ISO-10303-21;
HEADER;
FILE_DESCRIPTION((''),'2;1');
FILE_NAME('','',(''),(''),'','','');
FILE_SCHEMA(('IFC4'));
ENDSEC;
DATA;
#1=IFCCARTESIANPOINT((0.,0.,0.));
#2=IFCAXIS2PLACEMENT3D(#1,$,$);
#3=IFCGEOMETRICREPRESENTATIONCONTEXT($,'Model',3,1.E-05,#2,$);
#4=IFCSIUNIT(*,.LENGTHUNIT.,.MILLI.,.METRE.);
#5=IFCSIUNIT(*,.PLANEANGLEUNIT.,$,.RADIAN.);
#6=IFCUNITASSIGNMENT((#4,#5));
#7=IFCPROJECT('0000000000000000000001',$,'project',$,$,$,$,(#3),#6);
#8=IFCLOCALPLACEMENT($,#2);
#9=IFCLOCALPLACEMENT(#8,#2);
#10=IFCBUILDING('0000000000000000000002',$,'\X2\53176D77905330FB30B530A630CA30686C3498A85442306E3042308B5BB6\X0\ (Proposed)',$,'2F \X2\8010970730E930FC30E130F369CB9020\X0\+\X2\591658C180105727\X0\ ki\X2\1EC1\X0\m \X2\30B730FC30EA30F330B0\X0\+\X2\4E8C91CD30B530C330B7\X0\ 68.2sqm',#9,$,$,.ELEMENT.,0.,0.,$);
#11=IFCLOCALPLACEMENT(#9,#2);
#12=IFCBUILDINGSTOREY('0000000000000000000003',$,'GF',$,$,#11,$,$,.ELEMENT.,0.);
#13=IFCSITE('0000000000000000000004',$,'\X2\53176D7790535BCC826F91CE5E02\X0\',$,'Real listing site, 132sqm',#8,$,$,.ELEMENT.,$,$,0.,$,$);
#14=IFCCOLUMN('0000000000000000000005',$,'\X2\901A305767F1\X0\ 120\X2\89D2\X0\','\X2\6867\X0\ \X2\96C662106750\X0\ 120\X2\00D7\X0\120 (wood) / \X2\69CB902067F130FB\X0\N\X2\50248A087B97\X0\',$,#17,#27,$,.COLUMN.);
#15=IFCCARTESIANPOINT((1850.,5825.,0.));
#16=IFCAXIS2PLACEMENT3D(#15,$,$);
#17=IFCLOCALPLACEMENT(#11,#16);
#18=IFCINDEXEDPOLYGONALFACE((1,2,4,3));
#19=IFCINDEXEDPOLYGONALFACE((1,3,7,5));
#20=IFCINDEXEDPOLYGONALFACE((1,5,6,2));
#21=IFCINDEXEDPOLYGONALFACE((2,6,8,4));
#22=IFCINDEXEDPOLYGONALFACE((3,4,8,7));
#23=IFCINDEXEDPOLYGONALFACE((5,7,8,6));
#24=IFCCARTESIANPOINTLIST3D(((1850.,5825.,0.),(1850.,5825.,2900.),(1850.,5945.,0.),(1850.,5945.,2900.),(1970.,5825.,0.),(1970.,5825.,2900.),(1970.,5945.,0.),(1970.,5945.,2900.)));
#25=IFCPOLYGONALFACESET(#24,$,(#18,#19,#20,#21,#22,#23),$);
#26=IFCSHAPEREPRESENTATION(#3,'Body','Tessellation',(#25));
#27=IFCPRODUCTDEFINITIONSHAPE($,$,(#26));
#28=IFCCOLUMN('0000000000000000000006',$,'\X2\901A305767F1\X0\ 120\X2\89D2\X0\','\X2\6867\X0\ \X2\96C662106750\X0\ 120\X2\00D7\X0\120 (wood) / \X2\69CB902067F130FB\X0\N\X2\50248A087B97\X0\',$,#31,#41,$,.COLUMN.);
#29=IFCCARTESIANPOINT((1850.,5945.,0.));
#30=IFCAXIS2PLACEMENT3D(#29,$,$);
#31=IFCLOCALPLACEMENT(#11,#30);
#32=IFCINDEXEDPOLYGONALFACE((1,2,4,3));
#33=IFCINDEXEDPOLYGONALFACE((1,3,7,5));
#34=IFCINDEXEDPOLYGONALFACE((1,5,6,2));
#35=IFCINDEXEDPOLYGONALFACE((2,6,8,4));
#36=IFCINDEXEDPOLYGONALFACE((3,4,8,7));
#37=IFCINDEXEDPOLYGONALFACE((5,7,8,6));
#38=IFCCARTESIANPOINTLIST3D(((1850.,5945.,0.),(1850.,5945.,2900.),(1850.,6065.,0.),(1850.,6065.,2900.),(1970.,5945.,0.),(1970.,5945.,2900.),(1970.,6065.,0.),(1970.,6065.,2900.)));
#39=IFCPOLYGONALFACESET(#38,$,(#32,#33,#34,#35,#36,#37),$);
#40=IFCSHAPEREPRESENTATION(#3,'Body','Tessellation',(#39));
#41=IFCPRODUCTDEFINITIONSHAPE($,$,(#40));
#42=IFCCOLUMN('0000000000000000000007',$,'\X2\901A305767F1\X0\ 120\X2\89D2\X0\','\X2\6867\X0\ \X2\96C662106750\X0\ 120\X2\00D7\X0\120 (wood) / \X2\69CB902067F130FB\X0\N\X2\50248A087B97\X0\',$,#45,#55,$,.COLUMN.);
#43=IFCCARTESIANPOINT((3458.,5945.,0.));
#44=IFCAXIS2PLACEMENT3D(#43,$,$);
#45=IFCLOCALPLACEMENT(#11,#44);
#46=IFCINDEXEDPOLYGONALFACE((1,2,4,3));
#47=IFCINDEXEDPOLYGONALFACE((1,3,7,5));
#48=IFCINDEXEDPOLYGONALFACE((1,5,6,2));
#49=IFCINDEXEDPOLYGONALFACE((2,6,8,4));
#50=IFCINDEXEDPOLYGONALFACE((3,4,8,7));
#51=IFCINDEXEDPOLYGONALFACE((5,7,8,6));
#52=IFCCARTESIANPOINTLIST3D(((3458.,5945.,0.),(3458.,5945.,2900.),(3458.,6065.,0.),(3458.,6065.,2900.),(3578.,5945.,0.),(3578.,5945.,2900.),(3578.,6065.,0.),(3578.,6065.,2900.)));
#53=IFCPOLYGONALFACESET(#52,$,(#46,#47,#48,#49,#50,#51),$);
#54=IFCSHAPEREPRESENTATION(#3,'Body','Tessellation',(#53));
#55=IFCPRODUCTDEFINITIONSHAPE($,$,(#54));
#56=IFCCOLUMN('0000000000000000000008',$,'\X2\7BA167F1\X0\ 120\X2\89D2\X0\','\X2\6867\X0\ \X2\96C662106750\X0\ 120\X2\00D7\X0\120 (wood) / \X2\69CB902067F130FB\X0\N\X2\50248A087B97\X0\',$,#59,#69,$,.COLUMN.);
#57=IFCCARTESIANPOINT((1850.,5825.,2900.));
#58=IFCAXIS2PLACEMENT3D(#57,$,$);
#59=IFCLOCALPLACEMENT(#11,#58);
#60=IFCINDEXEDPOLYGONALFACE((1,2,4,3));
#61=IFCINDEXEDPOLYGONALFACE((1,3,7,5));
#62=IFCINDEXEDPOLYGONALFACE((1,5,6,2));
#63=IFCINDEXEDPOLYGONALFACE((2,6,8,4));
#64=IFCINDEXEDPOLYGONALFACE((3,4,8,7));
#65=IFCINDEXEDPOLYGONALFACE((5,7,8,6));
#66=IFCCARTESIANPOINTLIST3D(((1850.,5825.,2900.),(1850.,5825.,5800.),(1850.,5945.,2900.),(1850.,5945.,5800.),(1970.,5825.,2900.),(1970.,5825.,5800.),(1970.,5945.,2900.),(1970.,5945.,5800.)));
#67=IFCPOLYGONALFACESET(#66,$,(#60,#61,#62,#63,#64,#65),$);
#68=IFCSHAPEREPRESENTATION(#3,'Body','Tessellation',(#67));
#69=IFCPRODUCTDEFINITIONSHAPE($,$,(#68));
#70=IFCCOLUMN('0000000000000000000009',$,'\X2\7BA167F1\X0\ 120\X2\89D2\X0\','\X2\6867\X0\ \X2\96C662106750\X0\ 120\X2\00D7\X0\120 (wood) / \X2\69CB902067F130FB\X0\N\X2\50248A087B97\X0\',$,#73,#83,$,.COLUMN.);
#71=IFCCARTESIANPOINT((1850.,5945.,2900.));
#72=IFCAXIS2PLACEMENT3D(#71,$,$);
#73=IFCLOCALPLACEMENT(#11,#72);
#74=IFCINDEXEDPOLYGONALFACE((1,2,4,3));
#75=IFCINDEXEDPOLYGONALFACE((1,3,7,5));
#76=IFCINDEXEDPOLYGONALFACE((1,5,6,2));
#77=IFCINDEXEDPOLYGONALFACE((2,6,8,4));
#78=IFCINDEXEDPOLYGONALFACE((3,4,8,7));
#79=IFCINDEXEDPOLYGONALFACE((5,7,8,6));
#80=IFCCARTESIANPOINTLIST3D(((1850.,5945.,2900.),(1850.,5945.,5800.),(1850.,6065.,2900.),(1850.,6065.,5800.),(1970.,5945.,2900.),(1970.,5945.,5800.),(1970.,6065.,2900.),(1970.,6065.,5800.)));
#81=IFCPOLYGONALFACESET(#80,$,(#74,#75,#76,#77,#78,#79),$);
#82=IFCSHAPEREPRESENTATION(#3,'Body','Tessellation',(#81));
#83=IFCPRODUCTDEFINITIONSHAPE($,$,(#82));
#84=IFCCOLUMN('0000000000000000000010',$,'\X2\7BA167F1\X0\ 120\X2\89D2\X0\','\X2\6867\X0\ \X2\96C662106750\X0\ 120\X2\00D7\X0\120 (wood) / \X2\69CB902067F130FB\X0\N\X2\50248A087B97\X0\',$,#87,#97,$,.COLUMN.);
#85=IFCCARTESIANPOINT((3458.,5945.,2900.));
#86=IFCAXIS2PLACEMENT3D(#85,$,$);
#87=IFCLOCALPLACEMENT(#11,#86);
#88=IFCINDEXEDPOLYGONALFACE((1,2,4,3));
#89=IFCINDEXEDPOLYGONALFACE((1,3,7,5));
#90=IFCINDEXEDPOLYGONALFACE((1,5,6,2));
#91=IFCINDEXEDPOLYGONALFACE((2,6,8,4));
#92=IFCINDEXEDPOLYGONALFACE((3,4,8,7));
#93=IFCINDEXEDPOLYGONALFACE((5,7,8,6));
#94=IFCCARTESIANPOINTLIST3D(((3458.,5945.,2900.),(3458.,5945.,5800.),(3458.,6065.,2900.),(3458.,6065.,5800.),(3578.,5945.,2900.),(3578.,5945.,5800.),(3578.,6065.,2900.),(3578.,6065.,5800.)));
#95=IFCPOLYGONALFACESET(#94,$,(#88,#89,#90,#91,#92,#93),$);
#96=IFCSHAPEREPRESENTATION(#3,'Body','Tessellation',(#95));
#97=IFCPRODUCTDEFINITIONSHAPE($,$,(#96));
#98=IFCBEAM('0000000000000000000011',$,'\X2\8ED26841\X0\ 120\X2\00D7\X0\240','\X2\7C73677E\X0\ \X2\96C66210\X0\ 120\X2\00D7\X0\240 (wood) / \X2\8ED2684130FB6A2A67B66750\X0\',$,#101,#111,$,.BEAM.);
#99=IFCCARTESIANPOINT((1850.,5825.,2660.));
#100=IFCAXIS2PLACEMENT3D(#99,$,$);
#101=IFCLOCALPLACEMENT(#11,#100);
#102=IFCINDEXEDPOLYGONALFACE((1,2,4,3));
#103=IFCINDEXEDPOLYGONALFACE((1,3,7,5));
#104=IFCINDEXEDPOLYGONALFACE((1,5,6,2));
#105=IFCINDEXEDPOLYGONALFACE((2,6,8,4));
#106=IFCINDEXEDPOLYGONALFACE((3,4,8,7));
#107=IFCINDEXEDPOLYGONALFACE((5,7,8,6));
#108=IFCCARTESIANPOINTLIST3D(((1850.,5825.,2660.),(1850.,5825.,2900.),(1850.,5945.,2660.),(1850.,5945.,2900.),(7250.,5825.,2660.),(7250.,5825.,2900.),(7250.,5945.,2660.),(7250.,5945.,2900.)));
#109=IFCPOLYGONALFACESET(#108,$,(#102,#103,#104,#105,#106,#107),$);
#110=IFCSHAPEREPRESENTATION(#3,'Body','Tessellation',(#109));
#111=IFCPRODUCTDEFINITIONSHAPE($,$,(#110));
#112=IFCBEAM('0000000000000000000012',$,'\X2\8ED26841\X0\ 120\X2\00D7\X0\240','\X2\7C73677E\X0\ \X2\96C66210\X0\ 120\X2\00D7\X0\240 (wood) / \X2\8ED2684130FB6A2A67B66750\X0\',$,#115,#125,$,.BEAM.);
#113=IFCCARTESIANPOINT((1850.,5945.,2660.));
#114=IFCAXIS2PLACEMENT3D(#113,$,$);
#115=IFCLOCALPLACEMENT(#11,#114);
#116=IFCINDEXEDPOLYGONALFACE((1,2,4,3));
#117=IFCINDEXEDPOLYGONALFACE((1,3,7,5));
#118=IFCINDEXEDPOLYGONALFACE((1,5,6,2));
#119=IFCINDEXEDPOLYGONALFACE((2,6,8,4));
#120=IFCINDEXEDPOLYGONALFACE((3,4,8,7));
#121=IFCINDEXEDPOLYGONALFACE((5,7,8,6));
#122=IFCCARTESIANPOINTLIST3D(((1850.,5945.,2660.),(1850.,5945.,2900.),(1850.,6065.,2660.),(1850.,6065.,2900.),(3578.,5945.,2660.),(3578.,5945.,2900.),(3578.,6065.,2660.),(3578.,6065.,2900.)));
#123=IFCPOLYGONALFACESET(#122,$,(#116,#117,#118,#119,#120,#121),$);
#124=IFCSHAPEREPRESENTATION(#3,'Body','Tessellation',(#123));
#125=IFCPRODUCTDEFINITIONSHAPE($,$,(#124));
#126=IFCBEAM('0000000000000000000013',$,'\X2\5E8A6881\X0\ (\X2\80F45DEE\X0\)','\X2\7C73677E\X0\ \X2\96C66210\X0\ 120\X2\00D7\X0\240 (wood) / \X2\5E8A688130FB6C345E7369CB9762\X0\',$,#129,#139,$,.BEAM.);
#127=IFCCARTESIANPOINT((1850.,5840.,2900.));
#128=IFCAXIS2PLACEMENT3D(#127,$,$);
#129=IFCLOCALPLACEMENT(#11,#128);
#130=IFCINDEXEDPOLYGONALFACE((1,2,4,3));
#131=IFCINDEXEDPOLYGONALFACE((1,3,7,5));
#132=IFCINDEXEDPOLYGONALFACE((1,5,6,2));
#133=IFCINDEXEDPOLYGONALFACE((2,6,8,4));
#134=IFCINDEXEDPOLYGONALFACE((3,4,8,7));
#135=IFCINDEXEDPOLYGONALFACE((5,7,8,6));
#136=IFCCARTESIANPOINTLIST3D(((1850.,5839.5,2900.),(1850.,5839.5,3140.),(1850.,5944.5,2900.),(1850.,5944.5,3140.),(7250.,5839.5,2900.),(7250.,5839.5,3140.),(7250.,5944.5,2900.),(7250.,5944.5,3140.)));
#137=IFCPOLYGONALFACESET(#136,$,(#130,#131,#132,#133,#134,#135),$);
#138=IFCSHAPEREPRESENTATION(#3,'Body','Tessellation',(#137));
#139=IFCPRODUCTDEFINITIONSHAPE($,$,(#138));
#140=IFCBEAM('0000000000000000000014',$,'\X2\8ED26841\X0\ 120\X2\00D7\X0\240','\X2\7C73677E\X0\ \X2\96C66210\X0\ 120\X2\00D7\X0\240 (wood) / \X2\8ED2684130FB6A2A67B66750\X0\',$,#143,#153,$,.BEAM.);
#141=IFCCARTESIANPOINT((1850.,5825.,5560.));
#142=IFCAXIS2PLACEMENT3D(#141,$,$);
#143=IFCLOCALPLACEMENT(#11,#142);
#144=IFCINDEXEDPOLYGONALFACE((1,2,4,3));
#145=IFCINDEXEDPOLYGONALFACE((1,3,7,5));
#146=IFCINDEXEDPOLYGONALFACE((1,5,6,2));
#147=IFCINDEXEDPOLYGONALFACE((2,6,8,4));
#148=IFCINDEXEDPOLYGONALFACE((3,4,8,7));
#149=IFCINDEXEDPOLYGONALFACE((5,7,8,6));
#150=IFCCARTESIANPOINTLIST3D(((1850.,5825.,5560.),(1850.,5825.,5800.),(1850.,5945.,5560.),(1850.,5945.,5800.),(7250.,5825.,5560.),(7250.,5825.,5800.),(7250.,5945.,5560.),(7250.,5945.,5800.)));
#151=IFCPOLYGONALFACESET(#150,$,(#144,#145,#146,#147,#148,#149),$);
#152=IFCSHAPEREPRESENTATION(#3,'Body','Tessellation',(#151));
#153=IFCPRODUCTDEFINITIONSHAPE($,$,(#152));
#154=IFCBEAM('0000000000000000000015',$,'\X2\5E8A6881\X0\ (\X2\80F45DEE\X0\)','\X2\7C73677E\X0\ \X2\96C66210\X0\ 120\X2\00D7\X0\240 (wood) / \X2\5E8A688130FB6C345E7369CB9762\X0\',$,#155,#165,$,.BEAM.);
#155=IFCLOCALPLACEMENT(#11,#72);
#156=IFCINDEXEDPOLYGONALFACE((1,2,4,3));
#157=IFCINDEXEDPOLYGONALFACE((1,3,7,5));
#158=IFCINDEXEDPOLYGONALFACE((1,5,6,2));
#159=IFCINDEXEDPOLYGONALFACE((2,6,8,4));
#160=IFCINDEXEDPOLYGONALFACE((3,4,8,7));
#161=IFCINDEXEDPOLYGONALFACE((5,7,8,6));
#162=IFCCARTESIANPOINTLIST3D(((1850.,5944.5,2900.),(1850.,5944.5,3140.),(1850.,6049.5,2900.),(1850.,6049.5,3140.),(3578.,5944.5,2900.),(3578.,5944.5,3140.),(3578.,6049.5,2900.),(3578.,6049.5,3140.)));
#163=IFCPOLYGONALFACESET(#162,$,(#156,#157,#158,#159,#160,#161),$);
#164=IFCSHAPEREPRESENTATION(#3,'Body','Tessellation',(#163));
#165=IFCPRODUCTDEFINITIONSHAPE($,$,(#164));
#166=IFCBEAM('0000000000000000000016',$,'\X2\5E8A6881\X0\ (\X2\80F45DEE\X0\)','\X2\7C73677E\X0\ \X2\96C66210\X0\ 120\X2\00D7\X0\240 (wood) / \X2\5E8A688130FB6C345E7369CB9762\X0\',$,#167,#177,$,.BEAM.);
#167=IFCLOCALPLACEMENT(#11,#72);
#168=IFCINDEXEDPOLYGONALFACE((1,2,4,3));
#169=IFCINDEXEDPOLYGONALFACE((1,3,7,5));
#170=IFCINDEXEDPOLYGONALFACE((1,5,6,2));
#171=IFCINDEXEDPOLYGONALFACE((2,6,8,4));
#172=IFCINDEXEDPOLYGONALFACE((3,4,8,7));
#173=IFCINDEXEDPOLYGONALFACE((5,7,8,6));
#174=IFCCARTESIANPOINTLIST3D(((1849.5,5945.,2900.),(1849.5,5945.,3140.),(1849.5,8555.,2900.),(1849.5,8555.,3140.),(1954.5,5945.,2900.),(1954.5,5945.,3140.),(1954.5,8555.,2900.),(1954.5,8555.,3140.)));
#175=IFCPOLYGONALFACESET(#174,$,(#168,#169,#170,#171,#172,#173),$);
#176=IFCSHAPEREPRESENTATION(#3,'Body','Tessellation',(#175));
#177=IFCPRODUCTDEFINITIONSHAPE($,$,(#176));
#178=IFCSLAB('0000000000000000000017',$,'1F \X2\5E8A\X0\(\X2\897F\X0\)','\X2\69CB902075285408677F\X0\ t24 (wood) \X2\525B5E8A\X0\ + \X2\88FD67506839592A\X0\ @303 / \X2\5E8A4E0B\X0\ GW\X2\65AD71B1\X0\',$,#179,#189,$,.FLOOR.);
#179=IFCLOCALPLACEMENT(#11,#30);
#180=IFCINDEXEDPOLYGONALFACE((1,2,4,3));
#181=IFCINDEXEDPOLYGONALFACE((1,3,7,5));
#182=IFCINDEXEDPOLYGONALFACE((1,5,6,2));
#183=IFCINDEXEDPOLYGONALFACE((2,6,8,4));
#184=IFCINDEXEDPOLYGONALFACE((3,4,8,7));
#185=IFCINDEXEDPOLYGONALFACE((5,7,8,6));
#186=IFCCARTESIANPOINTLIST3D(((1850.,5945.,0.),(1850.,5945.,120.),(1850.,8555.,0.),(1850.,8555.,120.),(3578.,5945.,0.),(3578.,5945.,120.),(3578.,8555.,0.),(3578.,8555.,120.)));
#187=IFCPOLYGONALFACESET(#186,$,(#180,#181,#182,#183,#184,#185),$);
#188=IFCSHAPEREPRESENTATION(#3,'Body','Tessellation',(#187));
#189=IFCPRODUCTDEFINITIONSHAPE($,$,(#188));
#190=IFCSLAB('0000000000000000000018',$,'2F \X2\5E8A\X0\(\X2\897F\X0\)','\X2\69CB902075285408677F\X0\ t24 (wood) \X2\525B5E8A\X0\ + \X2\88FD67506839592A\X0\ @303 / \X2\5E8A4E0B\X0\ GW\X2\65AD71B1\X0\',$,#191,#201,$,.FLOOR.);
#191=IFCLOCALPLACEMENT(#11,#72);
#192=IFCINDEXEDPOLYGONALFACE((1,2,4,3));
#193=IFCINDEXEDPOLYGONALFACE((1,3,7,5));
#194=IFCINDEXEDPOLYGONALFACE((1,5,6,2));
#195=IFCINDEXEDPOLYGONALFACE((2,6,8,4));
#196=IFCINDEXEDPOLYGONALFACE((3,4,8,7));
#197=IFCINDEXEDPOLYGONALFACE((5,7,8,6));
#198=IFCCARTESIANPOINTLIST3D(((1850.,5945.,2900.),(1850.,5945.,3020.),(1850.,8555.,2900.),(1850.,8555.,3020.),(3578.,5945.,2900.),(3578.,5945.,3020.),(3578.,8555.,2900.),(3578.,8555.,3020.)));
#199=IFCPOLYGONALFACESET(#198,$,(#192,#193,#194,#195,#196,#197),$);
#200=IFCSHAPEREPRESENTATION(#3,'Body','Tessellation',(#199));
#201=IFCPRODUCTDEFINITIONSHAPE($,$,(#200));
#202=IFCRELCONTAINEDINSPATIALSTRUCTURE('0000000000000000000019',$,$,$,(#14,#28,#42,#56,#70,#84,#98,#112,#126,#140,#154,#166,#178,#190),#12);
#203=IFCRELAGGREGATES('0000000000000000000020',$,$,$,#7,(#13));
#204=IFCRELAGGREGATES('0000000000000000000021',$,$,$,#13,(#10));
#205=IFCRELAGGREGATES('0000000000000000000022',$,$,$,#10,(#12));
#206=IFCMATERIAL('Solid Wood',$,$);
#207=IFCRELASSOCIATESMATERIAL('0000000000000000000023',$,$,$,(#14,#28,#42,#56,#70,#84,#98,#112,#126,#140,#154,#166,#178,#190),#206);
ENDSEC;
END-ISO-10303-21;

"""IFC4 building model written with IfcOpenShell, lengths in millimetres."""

from ifc_helpers import new_model, si_unit, frame, frame_2d, origin, place, context, project, spatial, rectangle, extrude, material, element, save


model = new_model("IFC4")

# Units and contexts
model_context = context("Model", 3, precision=1e-05, world=origin())
ifc_project = project(units=[si_unit("LENGTHUNIT", "METRE", prefix="MILLI"), si_unit("PLANEANGLEUNIT", "RADIAN")], contexts=[model_context])

# Site, building, storey
site_placement = place(None, origin())
site = spatial("IfcSite", under=ifc_project, at=site_placement, Name="北海道富良野市", ObjectType="Real listing site, 132sqm", CompositionType="ELEMENT", RefElevation=0.0)
building_placement = place(site_placement, origin())
building = spatial("IfcBuilding", under=site, at=building_placement, Name="北海道・サウナと水風呂のある家 (Proposed)", ObjectType="2F 耐震ラーメン構造+外壁耐圧 kiềm シーリング+二重サッシ 68.2sqm", CompositionType="ELEMENT", ElevationOfRefHeight=0.0, ElevationOfTerrain=0.0)
storey_placement = place(building_placement, origin())
storey = spatial("IfcBuildingStorey", under=building, at=storey_placement, Name="GF", CompositionType="ELEMENT", Elevation=0.0)

# Columns
ifc_material_1 = material(Name="Solid Wood")
column_1_placement = place(storey_placement, frame((1850.0, 5825.0, 0.0)))
element("IfcColumn", 1, at=column_1_placement, inside=storey, material=ifc_material_1, Name="通し柱 120角", Description="桧 集成材 120×120 (wood) / 構造柱・N値計算", PredefinedType="COLUMN", context=model_context, shape_type="SweptSolid", body=[
    extrude(rectangle(XDim=120.0, YDim=120.0, at=frame_2d((60.0, 60.0))), frame((1850.0, 5825.0, 0.0)), (0.0, 0.0, 1.0), 2900.0),
])
column_2_placement = place(storey_placement, frame((1850.0, 5945.0, 0.0)))
element("IfcColumn", 2, at=column_2_placement, inside=storey, material=ifc_material_1, Name="通し柱 120角", Description="桧 集成材 120×120 (wood) / 構造柱・N値計算", PredefinedType="COLUMN", context=model_context, shape_type="SweptSolid", body=[
    extrude(rectangle(XDim=120.0, YDim=120.0, at=frame_2d((60.0, 60.0))), frame((1850.0, 5945.0, 0.0)), (0.0, 0.0, 1.0), 2900.0),
])
column_3_placement = place(storey_placement, frame((3458.0, 5945.0, 0.0)))
element("IfcColumn", 3, at=column_3_placement, inside=storey, material=ifc_material_1, Name="通し柱 120角", Description="桧 集成材 120×120 (wood) / 構造柱・N値計算", PredefinedType="COLUMN", context=model_context, shape_type="SweptSolid", body=[
    extrude(rectangle(XDim=120.0, YDim=120.0, at=frame_2d((60.0, 60.0))), frame((3458.0, 5945.0, 0.0)), (0.0, 0.0, 1.0), 2900.0),
])
column_4_placement = place(storey_placement, frame((1850.0, 5825.0, 2900.0)))
element("IfcColumn", 4, at=column_4_placement, inside=storey, material=ifc_material_1, Name="管柱 120角", Description="桧 集成材 120×120 (wood) / 構造柱・N値計算", PredefinedType="COLUMN", context=model_context, shape_type="SweptSolid", body=[
    extrude(rectangle(XDim=120.0, YDim=120.0, at=frame_2d((60.0, 60.0))), frame((1850.0, 5825.0, 2900.0)), (0.0, 0.0, 1.0), 2900.0),
])
column_5_placement = place(storey_placement, frame((1850.0, 5945.0, 2900.0)))
element("IfcColumn", 5, at=column_5_placement, inside=storey, material=ifc_material_1, Name="管柱 120角", Description="桧 集成材 120×120 (wood) / 構造柱・N値計算", PredefinedType="COLUMN", context=model_context, shape_type="SweptSolid", body=[
    extrude(rectangle(XDim=120.0, YDim=120.0, at=frame_2d((60.0, 60.0))), frame((1850.0, 5945.0, 2900.0)), (0.0, 0.0, 1.0), 2900.0),
])
column_6_placement = place(storey_placement, frame((3458.0, 5945.0, 2900.0)))
element("IfcColumn", 6, at=column_6_placement, inside=storey, material=ifc_material_1, Name="管柱 120角", Description="桧 集成材 120×120 (wood) / 構造柱・N値計算", PredefinedType="COLUMN", context=model_context, shape_type="SweptSolid", body=[
    extrude(rectangle(XDim=120.0, YDim=120.0, at=frame_2d((60.0, 60.0))), frame((3458.0, 5945.0, 2900.0)), (0.0, 0.0, 1.0), 2900.0),
])

# Beams
beam_1_placement = place(storey_placement, frame((1850.0, 5825.0, 2660.0)))
element("IfcBeam", 7, at=beam_1_placement, inside=storey, material=ifc_material_1, Name="軒桁 120×240", Description="米松 集成 120×240 (wood) / 軒桁・横架材", PredefinedType="BEAM", context=model_context, shape_type="SweptSolid", body=[
    extrude(rectangle(XDim=5400.0, YDim=120.0, at=frame_2d((2700.0, 60.0))), frame((1850.0, 5825.0, 2660.0)), (0.0, 0.0, 1.0), 240.0),
])
beam_2_placement = place(storey_placement, frame((1850.0, 5945.0, 2660.0)))
element("IfcBeam", 8, at=beam_2_placement, inside=storey, material=ifc_material_1, Name="軒桁 120×240", Description="米松 集成 120×240 (wood) / 軒桁・横架材", PredefinedType="BEAM", context=model_context, shape_type="SweptSolid", body=[
    extrude(rectangle(XDim=1728.0, YDim=120.0, at=frame_2d((864.0, 60.0))), frame((1850.0, 5945.0, 2660.0)), (0.0, 0.0, 1.0), 240.0),
])
beam_3_placement = place(storey_placement, frame((1850.0, 5840.0, 2900.0)))
element("IfcBeam", 9, at=beam_3_placement, inside=storey, material=ifc_material_1, Name="床梁 (胴差)", Description="米松 集成 120×240 (wood) / 床梁・水平構面", PredefinedType="BEAM", context=model_context, shape_type="SweptSolid", body=[
    extrude(rectangle(XDim=5400.0, YDim=105.0, at=frame_2d((2700.0, 52.0))), frame((1850.0, 5840.0, 2900.0)), (0.0, 0.0, 1.0), 240.0),
])
beam_4_placement = place(storey_placement, frame((1850.0, 5825.0, 5560.0)))
element("IfcBeam", 10, at=beam_4_placement, inside=storey, material=ifc_material_1, Name="軒桁 120×240", Description="米松 集成 120×240 (wood) / 軒桁・横架材", PredefinedType="BEAM", context=model_context, shape_type="SweptSolid", body=[
    extrude(rectangle(XDim=5400.0, YDim=120.0, at=frame_2d((2700.0, 60.0))), frame((1850.0, 5825.0, 5560.0)), (0.0, 0.0, 1.0), 240.0),
])
beam_5_placement = place(storey_placement, frame((1850.0, 5945.0, 2900.0)))
element("IfcBeam", 11, at=beam_5_placement, inside=storey, material=ifc_material_1, Name="床梁 (胴差)", Description="米松 集成 120×240 (wood) / 床梁・水平構面", PredefinedType="BEAM", context=model_context, shape_type="SweptSolid", body=[
    extrude(rectangle(XDim=1728.0, YDim=105.0, at=frame_2d((864.0, 52.0))), frame((1850.0, 5945.0, 2900.0)), (0.0, 0.0, 1.0), 240.0),
])
beam_6_placement = place(storey_placement, frame((1850.0, 5945.0, 2900.0)))
element("IfcBeam", 12, at=beam_6_placement, inside=storey, material=ifc_material_1, Name="床梁 (胴差)", Description="米松 集成 120×240 (wood) / 床梁・水平構面", PredefinedType="BEAM", context=model_context, shape_type="SweptSolid", body=[
    extrude(rectangle(XDim=105.0, YDim=2610.0, at=frame_2d((52.0, 1305.0))), frame((1850.0, 5945.0, 2900.0)), (0.0, 0.0, 1.0), 240.0),
])

# Slabs
slab_1_placement = place(storey_placement, frame((1850.0, 5945.0, 0.0)))
element("IfcSlab", 13, at=slab_1_placement, inside=storey, material=ifc_material_1, Name="1F 床(西)", Description="構造用合板 t24 (wood) 剛床 + 製材根太 @303 / 床下 GW断熱", PredefinedType="FLOOR", context=model_context, shape_type="SweptSolid", body=[
    extrude(rectangle(XDim=1728.0, YDim=2610.0, at=frame_2d((864.0, 1305.0))), frame((1850.0, 5945.0, 0.0)), (0.0, 0.0, 1.0), 120.0),
])
slab_2_placement = place(storey_placement, frame((1850.0, 5945.0, 2900.0)))
element("IfcSlab", 14, at=slab_2_placement, inside=storey, material=ifc_material_1, Name="2F 床(西)", Description="構造用合板 t24 (wood) 剛床 + 製材根太 @303 / 床下 GW断熱", PredefinedType="FLOOR", context=model_context, shape_type="SweptSolid", body=[
    extrude(rectangle(XDim=1728.0, YDim=2610.0, at=frame_2d((864.0, 1305.0))), frame((1850.0, 5945.0, 2900.0)), (0.0, 0.0, 1.0), 120.0),
])

save(model, "model.ifc")
